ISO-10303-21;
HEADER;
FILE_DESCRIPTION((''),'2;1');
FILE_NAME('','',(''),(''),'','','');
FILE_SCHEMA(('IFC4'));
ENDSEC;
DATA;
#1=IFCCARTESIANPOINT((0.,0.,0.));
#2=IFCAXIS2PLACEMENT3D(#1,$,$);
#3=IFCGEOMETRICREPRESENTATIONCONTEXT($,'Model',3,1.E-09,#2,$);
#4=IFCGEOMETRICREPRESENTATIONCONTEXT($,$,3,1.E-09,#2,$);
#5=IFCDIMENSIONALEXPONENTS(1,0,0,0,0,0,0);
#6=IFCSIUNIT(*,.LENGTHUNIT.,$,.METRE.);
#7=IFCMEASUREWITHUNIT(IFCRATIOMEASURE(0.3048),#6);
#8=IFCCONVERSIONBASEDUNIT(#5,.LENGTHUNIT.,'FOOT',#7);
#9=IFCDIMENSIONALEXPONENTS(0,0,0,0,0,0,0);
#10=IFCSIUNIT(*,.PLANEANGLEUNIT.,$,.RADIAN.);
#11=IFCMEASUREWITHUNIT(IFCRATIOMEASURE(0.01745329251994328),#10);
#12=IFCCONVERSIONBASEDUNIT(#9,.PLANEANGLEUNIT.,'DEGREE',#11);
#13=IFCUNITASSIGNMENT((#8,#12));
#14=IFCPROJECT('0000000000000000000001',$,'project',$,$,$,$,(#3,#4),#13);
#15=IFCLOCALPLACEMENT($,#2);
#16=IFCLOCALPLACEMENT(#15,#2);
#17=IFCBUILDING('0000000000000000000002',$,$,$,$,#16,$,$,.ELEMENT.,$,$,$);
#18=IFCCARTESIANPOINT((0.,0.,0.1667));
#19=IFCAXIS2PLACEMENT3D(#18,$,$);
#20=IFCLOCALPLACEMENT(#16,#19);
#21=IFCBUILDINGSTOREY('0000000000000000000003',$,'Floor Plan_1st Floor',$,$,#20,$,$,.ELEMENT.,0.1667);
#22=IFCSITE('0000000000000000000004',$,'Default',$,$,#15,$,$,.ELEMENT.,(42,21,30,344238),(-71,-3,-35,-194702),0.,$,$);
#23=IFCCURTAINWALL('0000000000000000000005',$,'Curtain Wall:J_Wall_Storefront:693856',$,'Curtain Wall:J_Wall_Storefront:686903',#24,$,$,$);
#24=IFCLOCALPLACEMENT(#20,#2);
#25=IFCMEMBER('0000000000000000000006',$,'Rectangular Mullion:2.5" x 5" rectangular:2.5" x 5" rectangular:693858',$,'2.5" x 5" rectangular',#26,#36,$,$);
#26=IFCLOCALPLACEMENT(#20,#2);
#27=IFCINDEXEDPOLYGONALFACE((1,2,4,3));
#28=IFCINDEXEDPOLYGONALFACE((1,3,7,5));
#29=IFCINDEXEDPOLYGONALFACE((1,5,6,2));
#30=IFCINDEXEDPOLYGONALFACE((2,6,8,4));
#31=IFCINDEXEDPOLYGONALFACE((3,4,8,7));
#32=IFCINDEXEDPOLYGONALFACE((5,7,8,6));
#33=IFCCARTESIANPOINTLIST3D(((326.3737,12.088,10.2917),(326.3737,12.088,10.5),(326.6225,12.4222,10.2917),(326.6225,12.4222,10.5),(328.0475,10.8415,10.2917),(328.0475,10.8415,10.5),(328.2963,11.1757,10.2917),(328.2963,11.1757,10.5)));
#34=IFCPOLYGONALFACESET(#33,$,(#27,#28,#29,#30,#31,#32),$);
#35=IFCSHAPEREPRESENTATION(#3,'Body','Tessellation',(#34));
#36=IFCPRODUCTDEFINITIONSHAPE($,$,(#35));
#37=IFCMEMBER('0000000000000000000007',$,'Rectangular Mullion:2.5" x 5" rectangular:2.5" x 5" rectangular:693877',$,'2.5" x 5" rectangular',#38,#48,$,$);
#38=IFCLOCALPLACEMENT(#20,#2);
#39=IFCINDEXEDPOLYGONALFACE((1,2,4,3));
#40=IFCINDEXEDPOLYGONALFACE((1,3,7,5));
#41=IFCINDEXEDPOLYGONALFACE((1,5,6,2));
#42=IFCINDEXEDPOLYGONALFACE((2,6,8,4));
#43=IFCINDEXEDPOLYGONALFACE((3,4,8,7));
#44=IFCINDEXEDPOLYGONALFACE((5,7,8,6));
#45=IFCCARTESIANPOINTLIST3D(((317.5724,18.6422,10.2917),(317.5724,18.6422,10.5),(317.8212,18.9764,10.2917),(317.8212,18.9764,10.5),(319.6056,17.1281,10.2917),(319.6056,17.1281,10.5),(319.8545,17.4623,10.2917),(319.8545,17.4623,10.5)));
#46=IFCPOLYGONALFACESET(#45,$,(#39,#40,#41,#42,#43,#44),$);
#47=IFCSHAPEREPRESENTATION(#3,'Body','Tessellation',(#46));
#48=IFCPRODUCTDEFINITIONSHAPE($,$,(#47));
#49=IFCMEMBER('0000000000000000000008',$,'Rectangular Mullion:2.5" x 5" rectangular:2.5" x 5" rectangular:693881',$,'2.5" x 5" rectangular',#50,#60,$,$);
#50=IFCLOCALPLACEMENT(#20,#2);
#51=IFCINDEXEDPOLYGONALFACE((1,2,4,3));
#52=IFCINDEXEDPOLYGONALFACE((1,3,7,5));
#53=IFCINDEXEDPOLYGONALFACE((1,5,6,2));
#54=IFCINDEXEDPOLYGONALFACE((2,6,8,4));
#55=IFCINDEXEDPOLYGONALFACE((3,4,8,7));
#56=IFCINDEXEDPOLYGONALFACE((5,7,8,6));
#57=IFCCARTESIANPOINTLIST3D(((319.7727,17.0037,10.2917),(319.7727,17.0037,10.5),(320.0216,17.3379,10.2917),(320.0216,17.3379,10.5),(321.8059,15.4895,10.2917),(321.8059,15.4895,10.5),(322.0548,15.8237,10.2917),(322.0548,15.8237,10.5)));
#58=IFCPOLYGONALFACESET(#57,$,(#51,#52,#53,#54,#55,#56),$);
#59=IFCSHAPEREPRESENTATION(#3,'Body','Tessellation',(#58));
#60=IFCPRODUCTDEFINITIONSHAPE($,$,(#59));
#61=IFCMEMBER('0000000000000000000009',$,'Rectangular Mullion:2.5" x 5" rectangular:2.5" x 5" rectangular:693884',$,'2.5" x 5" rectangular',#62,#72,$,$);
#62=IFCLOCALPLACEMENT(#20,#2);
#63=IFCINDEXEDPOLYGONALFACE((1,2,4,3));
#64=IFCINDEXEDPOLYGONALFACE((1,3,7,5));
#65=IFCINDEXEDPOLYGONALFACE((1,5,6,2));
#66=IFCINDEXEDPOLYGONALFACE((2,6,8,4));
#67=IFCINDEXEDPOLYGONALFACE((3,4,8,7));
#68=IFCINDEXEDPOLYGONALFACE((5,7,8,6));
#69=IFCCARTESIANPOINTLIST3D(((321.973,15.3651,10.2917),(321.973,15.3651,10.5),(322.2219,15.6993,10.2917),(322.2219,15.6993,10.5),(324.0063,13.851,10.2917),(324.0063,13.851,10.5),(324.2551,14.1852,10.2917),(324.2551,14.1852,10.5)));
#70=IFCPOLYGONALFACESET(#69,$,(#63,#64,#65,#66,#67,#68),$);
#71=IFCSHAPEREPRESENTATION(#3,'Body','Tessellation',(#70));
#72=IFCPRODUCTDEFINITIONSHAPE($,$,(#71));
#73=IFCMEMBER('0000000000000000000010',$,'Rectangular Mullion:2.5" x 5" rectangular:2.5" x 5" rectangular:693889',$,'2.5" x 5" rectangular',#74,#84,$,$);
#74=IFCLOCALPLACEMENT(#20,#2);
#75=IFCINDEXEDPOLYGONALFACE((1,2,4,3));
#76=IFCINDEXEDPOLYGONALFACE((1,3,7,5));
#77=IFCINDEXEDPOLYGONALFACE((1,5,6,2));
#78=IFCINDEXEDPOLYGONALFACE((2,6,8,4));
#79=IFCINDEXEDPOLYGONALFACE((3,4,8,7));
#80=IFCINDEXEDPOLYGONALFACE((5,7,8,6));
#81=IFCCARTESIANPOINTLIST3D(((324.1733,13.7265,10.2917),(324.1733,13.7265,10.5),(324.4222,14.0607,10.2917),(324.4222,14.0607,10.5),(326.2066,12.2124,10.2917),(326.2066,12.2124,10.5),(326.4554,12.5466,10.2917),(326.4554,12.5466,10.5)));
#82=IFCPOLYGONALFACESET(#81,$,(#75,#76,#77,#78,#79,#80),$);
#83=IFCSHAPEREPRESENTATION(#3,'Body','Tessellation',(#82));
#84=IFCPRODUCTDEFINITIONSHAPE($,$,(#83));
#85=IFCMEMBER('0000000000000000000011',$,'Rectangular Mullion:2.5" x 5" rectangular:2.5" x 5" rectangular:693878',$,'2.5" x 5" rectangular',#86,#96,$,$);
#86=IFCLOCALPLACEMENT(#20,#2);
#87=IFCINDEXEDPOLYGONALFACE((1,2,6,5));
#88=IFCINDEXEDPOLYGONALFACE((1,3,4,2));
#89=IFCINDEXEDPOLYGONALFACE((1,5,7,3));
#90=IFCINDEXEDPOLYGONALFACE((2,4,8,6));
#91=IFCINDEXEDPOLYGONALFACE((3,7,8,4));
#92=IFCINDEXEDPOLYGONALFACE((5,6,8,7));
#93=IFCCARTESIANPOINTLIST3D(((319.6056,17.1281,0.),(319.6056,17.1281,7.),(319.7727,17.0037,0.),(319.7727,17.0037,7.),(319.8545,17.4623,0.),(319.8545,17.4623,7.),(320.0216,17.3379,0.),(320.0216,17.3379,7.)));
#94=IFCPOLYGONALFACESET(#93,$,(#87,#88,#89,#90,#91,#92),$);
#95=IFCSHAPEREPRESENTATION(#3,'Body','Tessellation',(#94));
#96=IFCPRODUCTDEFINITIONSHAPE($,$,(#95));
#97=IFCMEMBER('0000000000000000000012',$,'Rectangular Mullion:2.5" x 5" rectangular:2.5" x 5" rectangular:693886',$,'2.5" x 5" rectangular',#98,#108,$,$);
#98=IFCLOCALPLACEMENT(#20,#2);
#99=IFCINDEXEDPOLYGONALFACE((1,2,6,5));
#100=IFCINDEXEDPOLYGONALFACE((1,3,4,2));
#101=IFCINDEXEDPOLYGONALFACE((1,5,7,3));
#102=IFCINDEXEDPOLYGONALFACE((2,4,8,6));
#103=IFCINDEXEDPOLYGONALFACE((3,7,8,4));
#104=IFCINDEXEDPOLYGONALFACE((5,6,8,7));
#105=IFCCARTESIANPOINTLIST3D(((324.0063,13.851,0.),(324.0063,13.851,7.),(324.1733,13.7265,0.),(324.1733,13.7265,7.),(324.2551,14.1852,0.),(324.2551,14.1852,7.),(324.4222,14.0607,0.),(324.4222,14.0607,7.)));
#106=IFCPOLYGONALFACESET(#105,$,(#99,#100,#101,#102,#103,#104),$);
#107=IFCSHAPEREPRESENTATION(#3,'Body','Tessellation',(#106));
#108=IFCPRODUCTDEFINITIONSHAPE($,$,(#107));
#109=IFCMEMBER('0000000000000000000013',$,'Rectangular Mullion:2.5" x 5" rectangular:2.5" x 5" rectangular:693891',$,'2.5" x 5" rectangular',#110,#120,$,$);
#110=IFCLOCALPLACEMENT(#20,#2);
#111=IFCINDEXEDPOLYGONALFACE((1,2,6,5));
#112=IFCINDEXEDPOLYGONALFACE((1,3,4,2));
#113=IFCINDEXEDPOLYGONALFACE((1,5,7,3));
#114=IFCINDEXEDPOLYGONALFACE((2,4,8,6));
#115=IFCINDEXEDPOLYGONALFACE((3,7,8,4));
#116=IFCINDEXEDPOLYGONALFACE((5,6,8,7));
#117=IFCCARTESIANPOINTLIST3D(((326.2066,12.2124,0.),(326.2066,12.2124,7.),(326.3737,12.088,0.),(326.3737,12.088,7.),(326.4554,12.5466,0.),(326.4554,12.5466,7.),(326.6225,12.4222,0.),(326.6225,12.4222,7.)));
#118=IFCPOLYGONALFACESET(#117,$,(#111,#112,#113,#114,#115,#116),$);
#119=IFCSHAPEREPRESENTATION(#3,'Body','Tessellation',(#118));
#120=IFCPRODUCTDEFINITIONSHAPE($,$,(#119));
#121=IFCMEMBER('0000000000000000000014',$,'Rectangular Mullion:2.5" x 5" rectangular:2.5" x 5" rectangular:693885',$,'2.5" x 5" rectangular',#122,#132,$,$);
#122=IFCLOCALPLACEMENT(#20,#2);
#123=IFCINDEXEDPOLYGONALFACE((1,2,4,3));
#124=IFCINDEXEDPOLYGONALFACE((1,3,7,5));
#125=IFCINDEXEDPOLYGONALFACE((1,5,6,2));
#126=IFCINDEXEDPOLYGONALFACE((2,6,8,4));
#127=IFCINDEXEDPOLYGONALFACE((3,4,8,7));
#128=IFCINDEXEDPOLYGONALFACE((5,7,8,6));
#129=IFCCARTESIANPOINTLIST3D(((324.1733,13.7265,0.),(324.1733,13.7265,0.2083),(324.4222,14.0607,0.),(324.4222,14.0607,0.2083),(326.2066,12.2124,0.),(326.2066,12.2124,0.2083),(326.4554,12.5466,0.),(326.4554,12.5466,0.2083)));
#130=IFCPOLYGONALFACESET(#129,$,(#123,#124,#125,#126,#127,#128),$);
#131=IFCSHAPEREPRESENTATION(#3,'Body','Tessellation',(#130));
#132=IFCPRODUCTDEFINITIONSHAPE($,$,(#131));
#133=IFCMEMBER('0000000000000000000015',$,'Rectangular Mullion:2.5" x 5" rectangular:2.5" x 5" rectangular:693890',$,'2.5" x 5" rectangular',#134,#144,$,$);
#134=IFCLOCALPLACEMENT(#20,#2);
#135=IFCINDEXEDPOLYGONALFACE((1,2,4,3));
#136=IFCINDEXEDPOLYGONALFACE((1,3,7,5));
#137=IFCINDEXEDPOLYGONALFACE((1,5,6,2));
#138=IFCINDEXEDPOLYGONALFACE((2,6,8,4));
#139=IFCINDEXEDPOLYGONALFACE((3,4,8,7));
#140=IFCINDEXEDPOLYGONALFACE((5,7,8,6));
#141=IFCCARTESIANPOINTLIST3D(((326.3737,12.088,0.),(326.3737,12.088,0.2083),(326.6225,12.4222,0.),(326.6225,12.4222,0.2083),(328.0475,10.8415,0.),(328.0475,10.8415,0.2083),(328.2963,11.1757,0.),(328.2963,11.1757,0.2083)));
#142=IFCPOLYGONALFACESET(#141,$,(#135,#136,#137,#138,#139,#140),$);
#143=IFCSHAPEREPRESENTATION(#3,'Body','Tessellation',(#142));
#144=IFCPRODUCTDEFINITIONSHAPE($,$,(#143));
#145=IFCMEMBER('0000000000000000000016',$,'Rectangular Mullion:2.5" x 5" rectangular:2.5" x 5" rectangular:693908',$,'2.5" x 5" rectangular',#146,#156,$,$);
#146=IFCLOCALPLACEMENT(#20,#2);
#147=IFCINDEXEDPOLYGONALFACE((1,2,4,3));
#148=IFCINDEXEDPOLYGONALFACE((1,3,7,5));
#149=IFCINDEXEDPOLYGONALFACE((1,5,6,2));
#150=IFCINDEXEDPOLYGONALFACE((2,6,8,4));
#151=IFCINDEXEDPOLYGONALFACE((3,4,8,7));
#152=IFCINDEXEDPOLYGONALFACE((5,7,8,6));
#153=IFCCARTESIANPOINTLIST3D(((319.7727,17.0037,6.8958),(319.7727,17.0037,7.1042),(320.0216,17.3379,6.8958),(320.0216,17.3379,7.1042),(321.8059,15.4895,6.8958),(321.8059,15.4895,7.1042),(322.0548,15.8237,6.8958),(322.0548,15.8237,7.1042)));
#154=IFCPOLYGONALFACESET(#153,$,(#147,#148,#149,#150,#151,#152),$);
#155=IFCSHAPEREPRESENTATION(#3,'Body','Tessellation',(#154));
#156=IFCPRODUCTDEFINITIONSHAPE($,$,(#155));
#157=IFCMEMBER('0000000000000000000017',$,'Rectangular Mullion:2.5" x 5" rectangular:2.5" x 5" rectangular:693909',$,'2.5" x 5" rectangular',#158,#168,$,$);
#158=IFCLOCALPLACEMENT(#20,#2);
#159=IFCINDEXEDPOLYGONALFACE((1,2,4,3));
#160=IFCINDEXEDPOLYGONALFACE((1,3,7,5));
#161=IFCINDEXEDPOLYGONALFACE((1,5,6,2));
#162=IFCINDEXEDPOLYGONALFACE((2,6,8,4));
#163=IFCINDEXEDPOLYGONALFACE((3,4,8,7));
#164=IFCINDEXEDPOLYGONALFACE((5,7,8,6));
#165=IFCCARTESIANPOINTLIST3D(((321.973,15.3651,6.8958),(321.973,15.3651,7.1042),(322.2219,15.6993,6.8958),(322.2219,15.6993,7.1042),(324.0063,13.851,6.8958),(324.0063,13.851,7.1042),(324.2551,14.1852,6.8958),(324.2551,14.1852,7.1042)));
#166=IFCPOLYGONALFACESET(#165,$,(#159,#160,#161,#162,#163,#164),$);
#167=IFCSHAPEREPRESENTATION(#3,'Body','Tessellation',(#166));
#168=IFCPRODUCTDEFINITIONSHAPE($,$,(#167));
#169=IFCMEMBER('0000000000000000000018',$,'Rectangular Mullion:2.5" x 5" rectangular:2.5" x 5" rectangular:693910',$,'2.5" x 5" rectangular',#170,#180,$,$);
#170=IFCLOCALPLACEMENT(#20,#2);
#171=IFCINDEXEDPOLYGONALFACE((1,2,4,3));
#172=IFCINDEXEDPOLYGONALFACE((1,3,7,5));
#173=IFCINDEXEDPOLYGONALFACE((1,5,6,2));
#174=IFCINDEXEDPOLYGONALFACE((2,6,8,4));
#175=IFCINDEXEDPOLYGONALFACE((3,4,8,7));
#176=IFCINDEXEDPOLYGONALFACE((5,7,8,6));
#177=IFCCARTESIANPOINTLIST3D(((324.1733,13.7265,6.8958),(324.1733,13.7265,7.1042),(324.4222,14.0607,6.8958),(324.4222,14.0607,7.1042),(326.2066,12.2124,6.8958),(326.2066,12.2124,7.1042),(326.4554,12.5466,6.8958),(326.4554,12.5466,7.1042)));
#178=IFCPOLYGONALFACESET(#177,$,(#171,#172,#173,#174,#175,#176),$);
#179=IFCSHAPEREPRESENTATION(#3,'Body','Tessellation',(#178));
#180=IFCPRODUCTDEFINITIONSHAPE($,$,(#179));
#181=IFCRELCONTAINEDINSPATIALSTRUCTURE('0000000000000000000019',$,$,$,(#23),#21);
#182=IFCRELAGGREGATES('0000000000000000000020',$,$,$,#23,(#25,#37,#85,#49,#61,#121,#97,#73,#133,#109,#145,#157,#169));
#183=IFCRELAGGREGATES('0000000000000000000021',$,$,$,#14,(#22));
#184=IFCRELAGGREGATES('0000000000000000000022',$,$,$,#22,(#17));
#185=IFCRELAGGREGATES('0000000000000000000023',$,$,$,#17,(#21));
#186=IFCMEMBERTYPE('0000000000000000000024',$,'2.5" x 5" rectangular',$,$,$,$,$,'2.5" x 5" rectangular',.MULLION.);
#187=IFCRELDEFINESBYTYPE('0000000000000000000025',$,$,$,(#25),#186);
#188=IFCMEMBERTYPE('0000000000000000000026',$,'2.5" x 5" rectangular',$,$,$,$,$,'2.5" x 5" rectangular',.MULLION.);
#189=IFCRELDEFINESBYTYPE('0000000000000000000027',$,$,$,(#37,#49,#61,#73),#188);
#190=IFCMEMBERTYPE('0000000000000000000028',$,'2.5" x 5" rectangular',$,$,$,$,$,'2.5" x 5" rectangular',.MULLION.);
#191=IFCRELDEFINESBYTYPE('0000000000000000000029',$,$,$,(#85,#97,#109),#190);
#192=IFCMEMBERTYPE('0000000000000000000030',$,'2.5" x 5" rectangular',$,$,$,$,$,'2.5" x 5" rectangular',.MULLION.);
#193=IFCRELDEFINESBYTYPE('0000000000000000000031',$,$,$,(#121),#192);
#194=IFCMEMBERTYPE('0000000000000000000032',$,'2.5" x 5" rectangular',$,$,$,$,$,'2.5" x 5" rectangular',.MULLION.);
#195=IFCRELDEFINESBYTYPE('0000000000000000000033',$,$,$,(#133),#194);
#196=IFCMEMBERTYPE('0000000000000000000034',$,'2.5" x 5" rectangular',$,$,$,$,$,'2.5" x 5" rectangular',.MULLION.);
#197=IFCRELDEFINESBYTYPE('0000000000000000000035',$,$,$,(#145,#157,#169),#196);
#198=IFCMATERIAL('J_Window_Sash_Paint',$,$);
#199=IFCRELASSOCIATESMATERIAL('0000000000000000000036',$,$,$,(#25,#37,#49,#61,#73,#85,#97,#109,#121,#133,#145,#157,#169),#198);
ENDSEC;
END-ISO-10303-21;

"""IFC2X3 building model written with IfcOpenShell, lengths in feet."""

from ifc_helpers import new_model, entity, si_unit, converted_unit, frame, origin, origin_2d_with_axis, place, context, project, spatial, rectangle, extrude, source, transform, mapped, material, type_object, type_shapes, element, aggregate, save


model = new_model("IFC2X3")

# Units and contexts
model_context = context("Model", 3, precision=1e-09, world=origin())
context_of_model = context(None, 3, precision=1e-09, world=origin())
ifc_project = project(units=[converted_unit("LENGTHUNIT", "FOOT", entity("IfcRatioMeasure", 0.3048), si_unit("LENGTHUNIT", "METRE"), dimensions=[1, 0, 0, 0, 0, 0, 0]), converted_unit("PLANEANGLEUNIT", "DEGREE", entity("IfcRatioMeasure", 0.01745329251994328), si_unit("PLANEANGLEUNIT", "RADIAN"), dimensions=[0, 0, 0, 0, 0, 0, 0])], contexts=[model_context, context_of_model])

# Site, building, storey
site_placement = place(None, origin())
site = spatial("IfcSite", under=ifc_project, at=site_placement, Name="Default", CompositionType="ELEMENT", RefLatitude=(42, 21, 30, 344238), RefLongitude=(-71, -3, -35, -194702), RefElevation=0.0)
building_placement = place(site_placement, origin())
building = spatial("IfcBuilding", under=site, at=building_placement, CompositionType="ELEMENT")
storey_placement = place(building_placement, frame((0.0, 0.0, 0.1667)))
storey = spatial("IfcBuildingStorey", under=building, at=storey_placement, Name="Floor Plan_1st Floor", CompositionType="ELEMENT", Elevation=0.1667)

# Curtain wall, members
curtain_wall_placement = place(storey_placement, origin())
curtain_wall = element("IfcCurtainWall", 1, at=curtain_wall_placement, inside=storey, Name="Curtain Wall:J_Wall_Storefront:693856", ObjectType="Curtain Wall:J_Wall_Storefront:686903")
ifc_material_1 = material(Name="J_Window_Sash_Paint")
member_type_1 = type_object("IfcMemberType", Name="2.5\" x 5\" rectangular", ElementType="2.5\" x 5\" rectangular", PredefinedType="MULLION")
shared_shape_1 = source(origin(), model_context, "Body", "SweptSolid", [
    extrude(rectangle(XDim=0.2083, YDim=0.4167, at=origin_2d_with_axis()), frame((-0.1042, 0.0, -2.0869), z_axis=(0.0, 0.0, 1.0), x_axis=(-1.0, 0.0, 0.0)), (0.0, 0.0, 1.0), 2.0869),
])
type_shapes(member_type_1, [shared_shape_1])
member_1_placement = place(storey_placement, frame((328.1719, 11.0086, 10.5), z_axis=(0.802039, -0.597272, 0.0), x_axis=(0.0, 0.0, 1.0)))
member_1 = element("IfcMember", 2, at=member_1_placement, type_object=member_type_1, material=ifc_material_1, Name="Rectangular Mullion:2.5\" x 5\" rectangular:2.5\" x 5\" rectangular:693858", ObjectType="2.5\" x 5\" rectangular", context=model_context, shape_type="MappedRepresentation", body=[
    mapped(shared_shape_1, transform((0.0, 0.0, 0.0), scale=1.0)),
])
member_type_2 = type_object("IfcMemberType", Name="2.5\" x 5\" rectangular", ElementType="2.5\" x 5\" rectangular", PredefinedType="MULLION")
shared_shape_2 = source(origin(), model_context, "Body", "SweptSolid", [
    extrude(rectangle(XDim=0.2083, YDim=0.4167, at=origin_2d_with_axis()), frame((-0.1042, 0.0, -2.5351), z_axis=(0.0, 0.0, 1.0), x_axis=(-1.0, 0.0, 0.0)), (0.0, 0.0, 1.0), 2.5351),
])
type_shapes(member_type_2, [shared_shape_2])
member_2_placement = place(storey_placement, frame((319.73, 17.2952, 10.5), z_axis=(0.802039, -0.597272, 0.0), x_axis=(0.0, 0.0, 1.0)))
member_2 = element("IfcMember", 3, at=member_2_placement, type_object=member_type_2, material=ifc_material_1, Name="Rectangular Mullion:2.5\" x 5\" rectangular:2.5\" x 5\" rectangular:693877", ObjectType="2.5\" x 5\" rectangular", context=model_context, shape_type="MappedRepresentation", body=[
    mapped(shared_shape_2, transform((0.0, 0.0, 0.0), scale=1.0)),
])
member_3_placement = place(storey_placement, frame((321.9304, 15.6566, 10.5), z_axis=(0.802039, -0.597272, 0.0), x_axis=(0.0, 0.0, 1.0)))
member_3 = element("IfcMember", 4, at=member_3_placement, type_object=member_type_2, material=ifc_material_1, Name="Rectangular Mullion:2.5\" x 5\" rectangular:2.5\" x 5\" rectangular:693881", ObjectType="2.5\" x 5\" rectangular", context=model_context, shape_type="MappedRepresentation", body=[
    mapped(shared_shape_2, transform((0.0, 0.0, 0.0), scale=1.0)),
])
member_4_placement = place(storey_placement, frame((324.1307, 14.0181, 10.5), z_axis=(0.802039, -0.597272, 0.0), x_axis=(0.0, 0.0, 1.0)))
member_4 = element("IfcMember", 5, at=member_4_placement, type_object=member_type_2, material=ifc_material_1, Name="Rectangular Mullion:2.5\" x 5\" rectangular:2.5\" x 5\" rectangular:693884", ObjectType="2.5\" x 5\" rectangular", context=model_context, shape_type="MappedRepresentation", body=[
    mapped(shared_shape_2, transform((0.0, 0.0, 0.0), scale=1.0)),
])
member_5_placement = place(storey_placement, frame((326.331, 12.3795, 10.5), z_axis=(0.802039, -0.597272, 0.0), x_axis=(0.0, 0.0, 1.0)))
member_5 = element("IfcMember", 6, at=member_5_placement, type_object=member_type_2, material=ifc_material_1, Name="Rectangular Mullion:2.5\" x 5\" rectangular:2.5\" x 5\" rectangular:693889", ObjectType="2.5\" x 5\" rectangular", context=model_context, shape_type="MappedRepresentation", body=[
    mapped(shared_shape_2, transform((0.0, 0.0, 0.0), scale=1.0)),
])
member_type_3 = type_object("IfcMemberType", Name="2.5\" x 5\" rectangular", ElementType="2.5\" x 5\" rectangular", PredefinedType="MULLION")
shared_shape_3 = source(origin(), model_context, "Body", "SweptSolid", [
    extrude(rectangle(XDim=0.2083, YDim=0.4167, at=origin_2d_with_axis()), frame((0.0, 0.0, -7.0), z_axis=(0.0, 0.0, 1.0), x_axis=(-1.0, 0.0, 0.0)), (0.0, 0.0, 1.0), 7.0),
])
type_shapes(member_type_3, [shared_shape_3])
member_6_placement = place(storey_placement, frame((319.8136, 17.233, 0.0), z_axis=(0.0, 0.0, -1.0), x_axis=(0.802039, -0.597272, 0.0)))
member_6 = element("IfcMember", 7, at=member_6_placement, type_object=member_type_3, material=ifc_material_1, Name="Rectangular Mullion:2.5\" x 5\" rectangular:2.5\" x 5\" rectangular:693878", ObjectType="2.5\" x 5\" rectangular", context=model_context, shape_type="MappedRepresentation", body=[
    mapped(shared_shape_3, transform((0.0, 0.0, 0.0), scale=1.0)),
])
member_7_placement = place(storey_placement, frame((324.2142, 13.9559, 0.0), z_axis=(0.0, 0.0, -1.0), x_axis=(0.802039, -0.597272, 0.0)))
member_7 = element("IfcMember", 8, at=member_7_placement, type_object=member_type_3, material=ifc_material_1, Name="Rectangular Mullion:2.5\" x 5\" rectangular:2.5\" x 5\" rectangular:693886", ObjectType="2.5\" x 5\" rectangular", context=model_context, shape_type="MappedRepresentation", body=[
    mapped(shared_shape_3, transform((0.0, 0.0, 0.0), scale=1.0)),
])
member_8_placement = place(storey_placement, frame((326.4146, 12.3173, 0.0), z_axis=(0.0, 0.0, -1.0), x_axis=(0.802039, -0.597272, 0.0)))
member_8 = element("IfcMember", 9, at=member_8_placement, type_object=member_type_3, material=ifc_material_1, Name="Rectangular Mullion:2.5\" x 5\" rectangular:2.5\" x 5\" rectangular:693891", ObjectType="2.5\" x 5\" rectangular", context=model_context, shape_type="MappedRepresentation", body=[
    mapped(shared_shape_3, transform((0.0, 0.0, 0.0), scale=1.0)),
])
member_type_4 = type_object("IfcMemberType", Name="2.5\" x 5\" rectangular", ElementType="2.5\" x 5\" rectangular", PredefinedType="MULLION")
shared_shape_4 = source(origin(), model_context, "Body", "SweptSolid", [
    extrude(rectangle(XDim=0.2083, YDim=0.4167, at=origin_2d_with_axis()), frame((-0.1042, 0.0, -2.5351), z_axis=(0.0, 0.0, 1.0), x_axis=(-1.0, 0.0, 0.0)), (0.0, 0.0, 1.0), 2.5351),
])
type_shapes(member_type_4, [shared_shape_4])
member_9_placement = place(storey_placement, frame((324.2978, 13.8936, 0.0), z_axis=(-0.802039, 0.597272, 0.0), x_axis=(0.0, 0.0, -1.0)))
member_9 = element("IfcMember", 10, at=member_9_placement, type_object=member_type_4, material=ifc_material_1, Name="Rectangular Mullion:2.5\" x 5\" rectangular:2.5\" x 5\" rectangular:693885", ObjectType="2.5\" x 5\" rectangular", context=model_context, shape_type="MappedRepresentation", body=[
    mapped(shared_shape_4, transform((0.0, 0.0, 0.0), scale=1.0)),
])
member_type_5 = type_object("IfcMemberType", Name="2.5\" x 5\" rectangular", ElementType="2.5\" x 5\" rectangular", PredefinedType="MULLION")
shared_shape_5 = source(origin(), model_context, "Body", "SweptSolid", [
    extrude(rectangle(XDim=0.2083, YDim=0.4167, at=origin_2d_with_axis()), frame((-0.1042, 0.0, -2.0869), z_axis=(0.0, 0.0, 1.0), x_axis=(-1.0, 0.0, 0.0)), (0.0, 0.0, 1.0), 2.0869),
])
type_shapes(member_type_5, [shared_shape_5])
member_10_placement = place(storey_placement, frame((326.4981, 12.2551, 0.0), z_axis=(-0.802039, 0.597272, 0.0), x_axis=(0.0, 0.0, -1.0)))
member_10 = element("IfcMember", 11, at=member_10_placement, type_object=member_type_5, material=ifc_material_1, Name="Rectangular Mullion:2.5\" x 5\" rectangular:2.5\" x 5\" rectangular:693890", ObjectType="2.5\" x 5\" rectangular", context=model_context, shape_type="MappedRepresentation", body=[
    mapped(shared_shape_5, transform((0.0, 0.0, 0.0), scale=1.0)),
])
member_type_6 = type_object("IfcMemberType", Name="2.5\" x 5\" rectangular", ElementType="2.5\" x 5\" rectangular", PredefinedType="MULLION")
shared_shape_6 = source(origin(), model_context, "Body", "SweptSolid", [
    extrude(rectangle(XDim=0.2083, YDim=0.4167, at=origin_2d_with_axis()), frame((0.0, 0.0, -2.5351), z_axis=(0.0, 0.0, 1.0), x_axis=(-1.0, 0.0, 0.0)), (0.0, 0.0, 1.0), 2.5351),
])
type_shapes(member_type_6, [shared_shape_6])
member_11_placement = place(storey_placement, frame((321.9304, 15.6566, 7.0), z_axis=(0.802039, -0.597272, 0.0), x_axis=(0.0, 0.0, 1.0)))
member_11 = element("IfcMember", 12, at=member_11_placement, type_object=member_type_6, material=ifc_material_1, Name="Rectangular Mullion:2.5\" x 5\" rectangular:2.5\" x 5\" rectangular:693908", ObjectType="2.5\" x 5\" rectangular", context=model_context, shape_type="MappedRepresentation", body=[
    mapped(shared_shape_6, transform((0.0, 0.0, 0.0), scale=1.0)),
])
member_12_placement = place(storey_placement, frame((324.1307, 14.0181, 7.0), z_axis=(0.802039, -0.597272, 0.0), x_axis=(0.0, 0.0, 1.0)))
member_12 = element("IfcMember", 13, at=member_12_placement, type_object=member_type_6, material=ifc_material_1, Name="Rectangular Mullion:2.5\" x 5\" rectangular:2.5\" x 5\" rectangular:693909", ObjectType="2.5\" x 5\" rectangular", context=model_context, shape_type="MappedRepresentation", body=[
    mapped(shared_shape_6, transform((0.0, 0.0, 0.0), scale=1.0)),
])
member_13_placement = place(storey_placement, frame((326.331, 12.3795, 7.0), z_axis=(0.802039, -0.597272, 0.0), x_axis=(0.0, 0.0, 1.0)))
member_13 = element("IfcMember", 14, at=member_13_placement, type_object=member_type_6, material=ifc_material_1, Name="Rectangular Mullion:2.5\" x 5\" rectangular:2.5\" x 5\" rectangular:693910", ObjectType="2.5\" x 5\" rectangular", context=model_context, shape_type="MappedRepresentation", body=[
    mapped(shared_shape_6, transform((0.0, 0.0, 0.0), scale=1.0)),
])
aggregate(curtain_wall, [member_1, member_2, member_6, member_3, member_4, member_9, member_7, member_5, member_10, member_8, member_11, member_12, member_13])

save(model, "model.ifc")
